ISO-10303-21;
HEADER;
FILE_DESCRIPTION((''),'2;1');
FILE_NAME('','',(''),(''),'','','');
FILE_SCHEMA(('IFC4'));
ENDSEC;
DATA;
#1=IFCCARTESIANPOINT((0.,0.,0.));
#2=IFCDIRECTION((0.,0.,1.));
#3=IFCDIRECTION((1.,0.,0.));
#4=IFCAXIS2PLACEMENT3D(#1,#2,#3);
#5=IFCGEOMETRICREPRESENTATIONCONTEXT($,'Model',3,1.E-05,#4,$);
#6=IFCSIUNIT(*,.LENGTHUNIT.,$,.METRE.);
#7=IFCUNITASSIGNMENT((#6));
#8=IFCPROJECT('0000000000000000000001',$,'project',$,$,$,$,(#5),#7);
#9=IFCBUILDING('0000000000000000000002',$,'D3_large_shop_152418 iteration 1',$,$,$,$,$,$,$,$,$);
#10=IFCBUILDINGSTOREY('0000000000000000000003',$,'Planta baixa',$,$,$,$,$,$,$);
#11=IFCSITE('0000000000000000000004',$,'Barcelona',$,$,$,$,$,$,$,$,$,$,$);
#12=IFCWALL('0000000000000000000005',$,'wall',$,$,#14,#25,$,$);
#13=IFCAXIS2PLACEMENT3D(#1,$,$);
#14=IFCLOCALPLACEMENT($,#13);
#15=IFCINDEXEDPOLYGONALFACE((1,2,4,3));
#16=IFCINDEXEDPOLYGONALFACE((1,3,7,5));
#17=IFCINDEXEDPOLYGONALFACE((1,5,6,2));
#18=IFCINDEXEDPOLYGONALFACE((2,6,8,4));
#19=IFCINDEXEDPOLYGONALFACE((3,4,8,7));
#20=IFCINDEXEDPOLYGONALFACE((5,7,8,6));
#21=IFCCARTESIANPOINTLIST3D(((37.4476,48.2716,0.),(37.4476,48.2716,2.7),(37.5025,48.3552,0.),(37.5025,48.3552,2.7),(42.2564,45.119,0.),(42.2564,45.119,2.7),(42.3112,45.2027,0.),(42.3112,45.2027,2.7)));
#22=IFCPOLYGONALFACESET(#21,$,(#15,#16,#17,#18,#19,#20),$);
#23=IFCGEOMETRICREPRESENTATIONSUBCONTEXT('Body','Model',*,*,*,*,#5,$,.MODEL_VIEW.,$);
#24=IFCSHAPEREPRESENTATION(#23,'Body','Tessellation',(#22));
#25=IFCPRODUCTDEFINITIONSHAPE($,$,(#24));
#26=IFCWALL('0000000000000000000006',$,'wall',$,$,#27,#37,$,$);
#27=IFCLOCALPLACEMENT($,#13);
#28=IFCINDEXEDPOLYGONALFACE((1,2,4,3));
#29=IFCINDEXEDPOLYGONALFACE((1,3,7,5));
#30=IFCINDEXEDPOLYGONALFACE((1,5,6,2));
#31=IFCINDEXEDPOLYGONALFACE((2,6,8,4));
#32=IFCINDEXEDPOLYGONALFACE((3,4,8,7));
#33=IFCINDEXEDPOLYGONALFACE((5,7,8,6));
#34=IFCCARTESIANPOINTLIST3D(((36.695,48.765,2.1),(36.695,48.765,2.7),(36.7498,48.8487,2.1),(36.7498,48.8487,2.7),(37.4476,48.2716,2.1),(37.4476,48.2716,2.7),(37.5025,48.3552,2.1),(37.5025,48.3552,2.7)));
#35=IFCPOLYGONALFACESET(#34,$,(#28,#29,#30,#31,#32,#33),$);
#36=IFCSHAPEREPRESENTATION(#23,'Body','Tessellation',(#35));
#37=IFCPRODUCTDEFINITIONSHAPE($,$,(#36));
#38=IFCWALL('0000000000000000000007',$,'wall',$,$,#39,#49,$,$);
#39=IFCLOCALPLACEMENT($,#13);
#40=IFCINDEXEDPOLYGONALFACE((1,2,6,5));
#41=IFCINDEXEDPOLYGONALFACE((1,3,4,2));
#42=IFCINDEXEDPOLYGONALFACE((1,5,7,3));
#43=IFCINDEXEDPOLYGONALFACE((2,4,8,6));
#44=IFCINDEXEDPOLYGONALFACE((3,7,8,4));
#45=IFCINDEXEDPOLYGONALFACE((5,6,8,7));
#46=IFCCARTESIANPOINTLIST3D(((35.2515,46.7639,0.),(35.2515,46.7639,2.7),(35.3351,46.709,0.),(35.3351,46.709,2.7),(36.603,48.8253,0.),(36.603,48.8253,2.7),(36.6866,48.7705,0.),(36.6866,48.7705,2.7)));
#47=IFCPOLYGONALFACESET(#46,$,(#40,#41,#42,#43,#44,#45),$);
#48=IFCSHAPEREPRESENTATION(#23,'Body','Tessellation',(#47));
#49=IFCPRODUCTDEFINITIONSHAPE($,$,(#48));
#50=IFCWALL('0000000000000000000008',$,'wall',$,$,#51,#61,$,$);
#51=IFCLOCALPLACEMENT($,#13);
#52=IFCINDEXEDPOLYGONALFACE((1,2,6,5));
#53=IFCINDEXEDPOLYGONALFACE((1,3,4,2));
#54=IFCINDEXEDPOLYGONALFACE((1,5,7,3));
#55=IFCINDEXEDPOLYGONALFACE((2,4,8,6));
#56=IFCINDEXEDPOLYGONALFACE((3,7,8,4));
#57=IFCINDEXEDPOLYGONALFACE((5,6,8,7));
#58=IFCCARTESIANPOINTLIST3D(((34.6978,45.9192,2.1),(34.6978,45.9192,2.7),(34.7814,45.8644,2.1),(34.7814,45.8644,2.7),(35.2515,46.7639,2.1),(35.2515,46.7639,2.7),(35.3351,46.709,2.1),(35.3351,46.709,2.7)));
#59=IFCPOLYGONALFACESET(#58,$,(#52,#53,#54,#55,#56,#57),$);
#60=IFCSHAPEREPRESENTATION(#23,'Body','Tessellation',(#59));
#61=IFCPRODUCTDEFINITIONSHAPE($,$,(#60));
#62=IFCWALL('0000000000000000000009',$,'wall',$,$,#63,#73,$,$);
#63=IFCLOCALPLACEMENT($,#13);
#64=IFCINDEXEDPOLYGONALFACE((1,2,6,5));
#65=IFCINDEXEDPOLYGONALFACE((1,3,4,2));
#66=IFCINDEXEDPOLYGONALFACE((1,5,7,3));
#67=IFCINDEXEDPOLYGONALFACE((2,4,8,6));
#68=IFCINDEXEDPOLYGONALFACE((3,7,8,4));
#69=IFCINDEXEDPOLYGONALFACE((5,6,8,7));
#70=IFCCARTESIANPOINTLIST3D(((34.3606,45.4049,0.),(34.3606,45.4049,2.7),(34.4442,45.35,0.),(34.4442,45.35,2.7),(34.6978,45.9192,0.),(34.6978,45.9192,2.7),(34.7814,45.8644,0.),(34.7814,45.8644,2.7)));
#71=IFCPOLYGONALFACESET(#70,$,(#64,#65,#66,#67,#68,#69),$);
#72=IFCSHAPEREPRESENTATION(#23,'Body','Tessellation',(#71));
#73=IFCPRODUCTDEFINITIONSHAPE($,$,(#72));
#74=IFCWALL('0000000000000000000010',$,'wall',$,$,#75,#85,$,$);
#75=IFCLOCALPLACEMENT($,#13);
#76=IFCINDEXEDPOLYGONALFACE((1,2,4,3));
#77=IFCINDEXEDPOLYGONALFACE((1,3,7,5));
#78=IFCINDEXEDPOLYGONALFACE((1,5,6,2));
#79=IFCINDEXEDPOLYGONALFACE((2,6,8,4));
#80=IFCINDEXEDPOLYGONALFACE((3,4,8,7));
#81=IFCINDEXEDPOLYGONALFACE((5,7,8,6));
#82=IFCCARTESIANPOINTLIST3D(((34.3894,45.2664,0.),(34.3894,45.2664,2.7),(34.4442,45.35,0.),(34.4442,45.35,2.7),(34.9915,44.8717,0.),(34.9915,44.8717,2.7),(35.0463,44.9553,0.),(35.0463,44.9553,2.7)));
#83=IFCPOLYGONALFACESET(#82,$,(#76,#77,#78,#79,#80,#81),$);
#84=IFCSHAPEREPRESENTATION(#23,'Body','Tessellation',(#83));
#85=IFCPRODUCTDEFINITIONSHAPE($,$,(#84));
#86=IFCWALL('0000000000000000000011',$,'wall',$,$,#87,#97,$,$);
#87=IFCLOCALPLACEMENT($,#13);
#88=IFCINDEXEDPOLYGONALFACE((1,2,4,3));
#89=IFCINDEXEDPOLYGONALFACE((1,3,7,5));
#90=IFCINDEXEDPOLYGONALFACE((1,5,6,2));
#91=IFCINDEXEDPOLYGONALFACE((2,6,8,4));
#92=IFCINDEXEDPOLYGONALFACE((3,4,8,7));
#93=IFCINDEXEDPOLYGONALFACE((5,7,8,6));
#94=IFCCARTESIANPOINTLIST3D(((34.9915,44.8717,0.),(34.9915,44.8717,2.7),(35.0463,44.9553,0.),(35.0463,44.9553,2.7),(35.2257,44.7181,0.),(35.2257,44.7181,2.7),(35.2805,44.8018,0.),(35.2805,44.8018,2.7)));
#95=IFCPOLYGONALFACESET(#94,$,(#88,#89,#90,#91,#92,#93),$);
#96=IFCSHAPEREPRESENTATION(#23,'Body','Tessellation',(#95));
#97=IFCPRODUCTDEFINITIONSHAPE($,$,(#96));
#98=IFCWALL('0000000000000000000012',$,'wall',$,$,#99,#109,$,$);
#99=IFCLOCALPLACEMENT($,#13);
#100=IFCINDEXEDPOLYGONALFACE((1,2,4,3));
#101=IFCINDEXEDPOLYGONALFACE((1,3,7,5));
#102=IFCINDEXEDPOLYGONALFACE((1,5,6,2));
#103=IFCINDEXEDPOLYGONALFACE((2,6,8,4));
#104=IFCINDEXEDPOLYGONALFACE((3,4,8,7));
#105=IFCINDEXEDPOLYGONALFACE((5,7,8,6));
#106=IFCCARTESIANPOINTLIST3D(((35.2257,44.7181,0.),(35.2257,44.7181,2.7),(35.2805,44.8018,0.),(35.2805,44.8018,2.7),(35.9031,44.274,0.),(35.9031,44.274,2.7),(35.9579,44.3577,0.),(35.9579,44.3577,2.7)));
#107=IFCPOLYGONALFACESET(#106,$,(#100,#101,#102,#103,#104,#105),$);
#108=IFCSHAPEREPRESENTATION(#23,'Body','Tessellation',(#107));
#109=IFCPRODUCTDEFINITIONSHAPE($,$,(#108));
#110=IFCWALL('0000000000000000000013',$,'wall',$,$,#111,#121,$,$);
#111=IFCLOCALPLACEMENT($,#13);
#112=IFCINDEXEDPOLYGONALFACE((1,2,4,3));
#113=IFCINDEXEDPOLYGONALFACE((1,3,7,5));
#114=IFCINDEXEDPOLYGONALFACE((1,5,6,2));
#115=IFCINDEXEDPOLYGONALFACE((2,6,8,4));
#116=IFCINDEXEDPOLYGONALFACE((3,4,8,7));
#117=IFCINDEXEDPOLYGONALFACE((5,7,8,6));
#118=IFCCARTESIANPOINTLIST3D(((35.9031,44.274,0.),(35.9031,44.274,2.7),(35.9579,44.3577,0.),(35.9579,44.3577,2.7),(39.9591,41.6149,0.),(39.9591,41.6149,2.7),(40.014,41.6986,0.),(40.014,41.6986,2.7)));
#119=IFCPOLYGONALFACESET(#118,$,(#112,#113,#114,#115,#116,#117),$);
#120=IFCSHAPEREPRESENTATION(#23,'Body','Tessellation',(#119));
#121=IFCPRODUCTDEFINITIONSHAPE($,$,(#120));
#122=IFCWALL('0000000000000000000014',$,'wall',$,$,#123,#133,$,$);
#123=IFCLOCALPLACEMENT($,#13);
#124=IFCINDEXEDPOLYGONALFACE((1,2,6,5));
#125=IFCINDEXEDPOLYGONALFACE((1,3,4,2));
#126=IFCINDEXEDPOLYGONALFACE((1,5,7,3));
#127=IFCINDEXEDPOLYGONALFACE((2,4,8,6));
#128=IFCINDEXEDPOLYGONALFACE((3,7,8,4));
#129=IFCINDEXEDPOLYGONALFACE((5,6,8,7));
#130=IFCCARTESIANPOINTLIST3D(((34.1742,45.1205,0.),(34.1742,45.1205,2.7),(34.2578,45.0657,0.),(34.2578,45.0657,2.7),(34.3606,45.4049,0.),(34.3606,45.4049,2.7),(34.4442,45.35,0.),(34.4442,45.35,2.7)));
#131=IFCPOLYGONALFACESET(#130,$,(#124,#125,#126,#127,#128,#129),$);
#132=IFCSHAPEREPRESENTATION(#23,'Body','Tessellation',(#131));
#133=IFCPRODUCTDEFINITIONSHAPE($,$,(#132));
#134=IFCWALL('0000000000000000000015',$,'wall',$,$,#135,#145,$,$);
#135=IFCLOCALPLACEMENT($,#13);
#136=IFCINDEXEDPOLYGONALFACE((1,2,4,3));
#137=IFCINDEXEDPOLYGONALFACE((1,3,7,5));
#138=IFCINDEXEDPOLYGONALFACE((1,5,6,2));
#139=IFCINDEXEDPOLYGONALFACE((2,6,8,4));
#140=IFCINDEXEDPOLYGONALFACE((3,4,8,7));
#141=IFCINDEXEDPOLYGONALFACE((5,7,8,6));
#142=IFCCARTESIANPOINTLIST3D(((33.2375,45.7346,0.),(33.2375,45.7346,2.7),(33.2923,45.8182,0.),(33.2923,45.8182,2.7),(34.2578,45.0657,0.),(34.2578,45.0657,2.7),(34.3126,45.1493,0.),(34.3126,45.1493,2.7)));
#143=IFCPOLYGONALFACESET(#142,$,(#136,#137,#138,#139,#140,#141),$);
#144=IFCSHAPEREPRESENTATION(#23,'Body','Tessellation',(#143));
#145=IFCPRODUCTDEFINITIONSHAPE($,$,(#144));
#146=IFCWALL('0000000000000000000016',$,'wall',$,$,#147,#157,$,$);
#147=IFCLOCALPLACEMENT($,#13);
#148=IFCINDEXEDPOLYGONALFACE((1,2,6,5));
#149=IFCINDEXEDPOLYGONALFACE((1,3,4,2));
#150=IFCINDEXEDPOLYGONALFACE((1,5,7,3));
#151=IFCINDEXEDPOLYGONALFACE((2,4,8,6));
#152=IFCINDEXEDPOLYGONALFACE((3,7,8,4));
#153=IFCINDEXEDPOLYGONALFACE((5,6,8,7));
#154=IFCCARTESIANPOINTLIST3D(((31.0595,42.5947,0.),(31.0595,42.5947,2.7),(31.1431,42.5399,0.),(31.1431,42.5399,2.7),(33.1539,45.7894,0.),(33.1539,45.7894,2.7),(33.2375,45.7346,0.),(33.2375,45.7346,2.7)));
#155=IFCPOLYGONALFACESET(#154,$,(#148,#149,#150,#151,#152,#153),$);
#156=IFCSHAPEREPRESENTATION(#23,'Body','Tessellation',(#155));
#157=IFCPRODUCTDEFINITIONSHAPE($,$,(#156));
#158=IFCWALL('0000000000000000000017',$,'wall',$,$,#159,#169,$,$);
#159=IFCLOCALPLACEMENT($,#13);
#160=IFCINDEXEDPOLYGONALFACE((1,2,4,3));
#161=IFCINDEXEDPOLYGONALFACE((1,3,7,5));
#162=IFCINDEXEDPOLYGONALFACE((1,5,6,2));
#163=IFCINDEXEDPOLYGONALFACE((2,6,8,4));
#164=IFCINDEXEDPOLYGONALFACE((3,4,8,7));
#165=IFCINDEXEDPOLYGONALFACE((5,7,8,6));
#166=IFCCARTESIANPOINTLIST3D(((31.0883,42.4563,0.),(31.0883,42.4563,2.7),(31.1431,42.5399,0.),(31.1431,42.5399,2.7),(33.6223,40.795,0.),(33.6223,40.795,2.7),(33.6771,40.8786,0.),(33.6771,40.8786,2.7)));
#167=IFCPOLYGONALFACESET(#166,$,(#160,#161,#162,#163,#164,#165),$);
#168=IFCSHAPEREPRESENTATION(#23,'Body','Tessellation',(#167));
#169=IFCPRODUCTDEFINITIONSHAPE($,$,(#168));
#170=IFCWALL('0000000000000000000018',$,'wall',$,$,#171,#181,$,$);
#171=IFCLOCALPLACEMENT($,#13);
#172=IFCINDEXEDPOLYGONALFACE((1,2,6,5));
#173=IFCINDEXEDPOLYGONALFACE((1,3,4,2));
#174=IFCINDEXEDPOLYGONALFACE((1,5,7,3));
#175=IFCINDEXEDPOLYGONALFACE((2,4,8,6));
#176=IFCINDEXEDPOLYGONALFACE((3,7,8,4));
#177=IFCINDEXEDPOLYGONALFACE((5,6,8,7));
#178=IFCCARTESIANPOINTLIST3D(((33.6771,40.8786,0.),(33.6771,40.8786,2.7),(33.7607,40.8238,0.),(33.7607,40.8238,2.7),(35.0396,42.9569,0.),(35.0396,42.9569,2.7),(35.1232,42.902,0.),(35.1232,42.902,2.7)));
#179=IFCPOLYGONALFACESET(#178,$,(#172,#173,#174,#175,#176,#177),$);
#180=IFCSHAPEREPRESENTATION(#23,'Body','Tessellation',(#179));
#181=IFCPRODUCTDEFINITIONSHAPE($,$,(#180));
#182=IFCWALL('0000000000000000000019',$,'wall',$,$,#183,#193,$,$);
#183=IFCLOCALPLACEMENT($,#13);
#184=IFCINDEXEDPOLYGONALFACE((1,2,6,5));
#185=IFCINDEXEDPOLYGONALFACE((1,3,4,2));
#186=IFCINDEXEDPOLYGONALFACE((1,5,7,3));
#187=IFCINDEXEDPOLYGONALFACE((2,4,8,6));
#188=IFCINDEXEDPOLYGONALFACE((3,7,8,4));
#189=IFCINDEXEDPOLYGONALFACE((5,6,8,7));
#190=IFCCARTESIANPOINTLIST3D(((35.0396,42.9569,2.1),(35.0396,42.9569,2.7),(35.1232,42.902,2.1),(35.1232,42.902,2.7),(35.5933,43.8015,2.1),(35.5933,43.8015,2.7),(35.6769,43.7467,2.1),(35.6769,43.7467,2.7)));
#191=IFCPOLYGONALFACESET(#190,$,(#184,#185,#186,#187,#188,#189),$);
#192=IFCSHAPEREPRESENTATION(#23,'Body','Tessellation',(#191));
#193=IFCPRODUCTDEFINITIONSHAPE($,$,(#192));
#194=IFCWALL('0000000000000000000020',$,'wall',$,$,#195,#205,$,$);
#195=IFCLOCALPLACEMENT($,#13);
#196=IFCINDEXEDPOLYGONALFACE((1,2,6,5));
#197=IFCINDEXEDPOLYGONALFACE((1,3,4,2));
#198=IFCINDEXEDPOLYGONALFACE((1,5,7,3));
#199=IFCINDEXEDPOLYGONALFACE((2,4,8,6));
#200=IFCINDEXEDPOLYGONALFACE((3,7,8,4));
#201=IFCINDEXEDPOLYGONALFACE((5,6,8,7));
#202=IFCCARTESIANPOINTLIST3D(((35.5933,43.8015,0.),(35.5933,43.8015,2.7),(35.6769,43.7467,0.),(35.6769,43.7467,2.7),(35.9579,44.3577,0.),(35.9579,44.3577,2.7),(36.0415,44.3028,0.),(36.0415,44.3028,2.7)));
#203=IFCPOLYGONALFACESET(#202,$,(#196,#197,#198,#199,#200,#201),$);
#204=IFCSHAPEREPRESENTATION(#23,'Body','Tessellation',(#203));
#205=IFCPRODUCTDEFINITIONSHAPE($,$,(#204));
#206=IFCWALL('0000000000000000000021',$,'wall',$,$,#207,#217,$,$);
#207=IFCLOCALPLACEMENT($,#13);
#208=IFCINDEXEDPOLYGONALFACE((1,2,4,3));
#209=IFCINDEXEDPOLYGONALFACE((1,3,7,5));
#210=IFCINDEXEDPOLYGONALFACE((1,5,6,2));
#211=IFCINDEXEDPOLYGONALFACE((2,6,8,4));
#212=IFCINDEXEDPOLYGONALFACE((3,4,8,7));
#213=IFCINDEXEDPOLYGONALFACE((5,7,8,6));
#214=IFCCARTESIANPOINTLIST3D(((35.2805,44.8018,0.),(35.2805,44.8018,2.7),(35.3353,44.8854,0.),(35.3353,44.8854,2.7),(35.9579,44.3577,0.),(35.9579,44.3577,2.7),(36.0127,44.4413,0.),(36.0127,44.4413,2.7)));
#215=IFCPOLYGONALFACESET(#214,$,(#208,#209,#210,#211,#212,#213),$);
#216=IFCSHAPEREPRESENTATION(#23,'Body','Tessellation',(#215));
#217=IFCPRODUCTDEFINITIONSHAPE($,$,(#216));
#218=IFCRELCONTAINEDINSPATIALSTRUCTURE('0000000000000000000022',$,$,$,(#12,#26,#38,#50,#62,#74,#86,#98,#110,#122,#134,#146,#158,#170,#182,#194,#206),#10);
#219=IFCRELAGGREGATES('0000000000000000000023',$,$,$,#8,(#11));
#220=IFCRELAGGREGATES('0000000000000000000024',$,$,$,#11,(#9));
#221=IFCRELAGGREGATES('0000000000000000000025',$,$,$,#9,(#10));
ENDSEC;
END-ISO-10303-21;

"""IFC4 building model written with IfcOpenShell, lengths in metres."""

from ifc_helpers import new_model, si_unit, frame, origin, origin_with_axes, place, context, subcontext, project, spatial, polyline, outline, extrude, element, save


model = new_model("IFC4")

# Units and contexts
model_context = context("Model", 3, precision=1e-05, world=origin_with_axes())
body_context = subcontext(model_context, "Body", "Model", "MODEL_VIEW")
ifc_project = project(units=[si_unit("LENGTHUNIT", "METRE")], contexts=[model_context])

# Site, building, storey
site = spatial("IfcSite", under=ifc_project, Name="Barcelona")
building = spatial("IfcBuilding", under=site, Name="D3_large_shop_152418 iteration 1")
storey = spatial("IfcBuildingStorey", under=building, Name="Planta baixa")

# Walls
wall_1_placement = place(None, origin_with_axes())
element("IfcWall", 1, at=wall_1_placement, inside=storey, Name="wall", context=body_context, shape_type="SweptSolid", body=[
    extrude(outline(polyline([(42.2564, 45.119), (37.4476, 48.2716), (37.5025, 48.3552), (42.3112, 45.2027), (42.2564, 45.119)])), origin(), (0.0, 0.0, 1.0), 2.7),
])
wall_2_placement = place(None, origin_with_axes())
element("IfcWall", 2, at=wall_2_placement, inside=storey, Name="wall", context=body_context, shape_type="SweptSolid", body=[
    extrude(outline(polyline([(37.4476, 48.2716), (36.695, 48.765), (36.7498, 48.8487), (37.5025, 48.3552), (37.4476, 48.2716)])), frame((0.0, 0.0, 2.1)), (0.0, 0.0, 1.0), 0.6),
])
wall_3_placement = place(None, origin_with_axes())
element("IfcWall", 3, at=wall_3_placement, inside=storey, Name="wall", context=body_context, shape_type="SweptSolid", body=[
    extrude(outline(polyline([(36.6866, 48.7705), (35.3351, 46.709), (35.2515, 46.7639), (36.603, 48.8253), (36.6866, 48.7705)])), origin(), (0.0, 0.0, 1.0), 2.7),
])
wall_4_placement = place(None, origin_with_axes())
element("IfcWall", 4, at=wall_4_placement, inside=storey, Name="wall", context=body_context, shape_type="SweptSolid", body=[
    extrude(outline(polyline([(35.3351, 46.709), (34.7814, 45.8644), (34.6978, 45.9192), (35.2515, 46.7639), (35.3351, 46.709)])), frame((0.0, 0.0, 2.1)), (0.0, 0.0, 1.0), 0.6),
])
wall_5_placement = place(None, origin_with_axes())
element("IfcWall", 5, at=wall_5_placement, inside=storey, Name="wall", context=body_context, shape_type="SweptSolid", body=[
    extrude(outline(polyline([(34.7814, 45.8644), (34.4442, 45.35), (34.3606, 45.4049), (34.6978, 45.9192), (34.7814, 45.8644)])), origin(), (0.0, 0.0, 1.0), 2.7),
])
wall_6_placement = place(None, origin_with_axes())
element("IfcWall", 6, at=wall_6_placement, inside=storey, Name="wall", context=body_context, shape_type="SweptSolid", body=[
    extrude(outline(polyline([(34.4442, 45.35), (35.0463, 44.9553), (34.9915, 44.8717), (34.3894, 45.2664), (34.4442, 45.35)])), origin(), (0.0, 0.0, 1.0), 2.7),
])
wall_7_placement = place(None, origin_with_axes())
element("IfcWall", 7, at=wall_7_placement, inside=storey, Name="wall", context=body_context, shape_type="SweptSolid", body=[
    extrude(outline(polyline([(35.0463, 44.9553), (35.2805, 44.8018), (35.2257, 44.7181), (34.9915, 44.8717), (35.0463, 44.9553)])), origin(), (0.0, 0.0, 1.0), 2.7),
])
wall_8_placement = place(None, origin_with_axes())
element("IfcWall", 8, at=wall_8_placement, inside=storey, Name="wall", context=body_context, shape_type="SweptSolid", body=[
    extrude(outline(polyline([(35.2805, 44.8018), (35.9579, 44.3577), (35.9031, 44.274), (35.2257, 44.7181), (35.2805, 44.8018)])), origin(), (0.0, 0.0, 1.0), 2.7),
])
wall_9_placement = place(None, origin_with_axes())
element("IfcWall", 9, at=wall_9_placement, inside=storey, Name="wall", context=body_context, shape_type="SweptSolid", body=[
    extrude(outline(polyline([(35.9579, 44.3577), (40.014, 41.6986), (39.9591, 41.6149), (35.9031, 44.274), (35.9579, 44.3577)])), origin(), (0.0, 0.0, 1.0), 2.7),
])
wall_10_placement = place(None, origin_with_axes())
element("IfcWall", 10, at=wall_10_placement, inside=storey, Name="wall", context=body_context, shape_type="SweptSolid", body=[
    extrude(outline(polyline([(34.4442, 45.35), (34.2578, 45.0657), (34.1742, 45.1205), (34.3606, 45.4049), (34.4442, 45.35)])), origin(), (0.0, 0.0, 1.0), 2.7),
])
wall_11_placement = place(None, origin_with_axes())
element("IfcWall", 11, at=wall_11_placement, inside=storey, Name="wall", context=body_context, shape_type="SweptSolid", body=[
    extrude(outline(polyline([(34.2578, 45.0657), (33.2375, 45.7346), (33.2923, 45.8182), (34.3126, 45.1493), (34.2578, 45.0657)])), origin(), (0.0, 0.0, 1.0), 2.7),
])
wall_12_placement = place(None, origin_with_axes())
element("IfcWall", 12, at=wall_12_placement, inside=storey, Name="wall", context=body_context, shape_type="SweptSolid", body=[
    extrude(outline(polyline([(33.2375, 45.7346), (31.1431, 42.5399), (31.0595, 42.5947), (33.1539, 45.7894), (33.2375, 45.7346)])), origin(), (0.0, 0.0, 1.0), 2.7),
])
wall_13_placement = place(None, origin_with_axes())
element("IfcWall", 13, at=wall_13_placement, inside=storey, Name="wall", context=body_context, shape_type="SweptSolid", body=[
    extrude(outline(polyline([(31.1431, 42.5399), (33.6771, 40.8786), (33.6223, 40.795), (31.0883, 42.4563), (31.1431, 42.5399)])), origin(), (0.0, 0.0, 1.0), 2.7),
])
wall_14_placement = place(None, origin_with_axes())
element("IfcWall", 14, at=wall_14_placement, inside=storey, Name="wall", context=body_context, shape_type="SweptSolid", body=[
    extrude(outline(polyline([(33.6771, 40.8786), (35.0396, 42.9569), (35.1232, 42.902), (33.7607, 40.8238), (33.6771, 40.8786)])), origin(), (0.0, 0.0, 1.0), 2.7),
])
wall_15_placement = place(None, origin_with_axes())
element("IfcWall", 15, at=wall_15_placement, inside=storey, Name="wall", context=body_context, shape_type="SweptSolid", body=[
    extrude(outline(polyline([(35.0396, 42.9569), (35.5933, 43.8015), (35.6769, 43.7467), (35.1232, 42.902), (35.0396, 42.9569)])), frame((0.0, 0.0, 2.1)), (0.0, 0.0, 1.0), 0.6),
])
wall_16_placement = place(None, origin_with_axes())
element("IfcWall", 16, at=wall_16_placement, inside=storey, Name="wall", context=body_context, shape_type="SweptSolid", body=[
    extrude(outline(polyline([(35.5933, 43.8015), (35.9579, 44.3577), (36.0415, 44.3028), (35.6769, 43.7467), (35.5933, 43.8015)])), origin(), (0.0, 0.0, 1.0), 2.7),
])
wall_17_placement = place(None, origin_with_axes())
element("IfcWall", 17, at=wall_17_placement, inside=storey, Name="wall", context=body_context, shape_type="SweptSolid", body=[
    extrude(outline(polyline([(35.9579, 44.3577), (35.2805, 44.8018), (35.3353, 44.8854), (36.0127, 44.4413), (35.9579, 44.3577)])), origin(), (0.0, 0.0, 1.0), 2.7),
])

save(model, "model.ifc")
